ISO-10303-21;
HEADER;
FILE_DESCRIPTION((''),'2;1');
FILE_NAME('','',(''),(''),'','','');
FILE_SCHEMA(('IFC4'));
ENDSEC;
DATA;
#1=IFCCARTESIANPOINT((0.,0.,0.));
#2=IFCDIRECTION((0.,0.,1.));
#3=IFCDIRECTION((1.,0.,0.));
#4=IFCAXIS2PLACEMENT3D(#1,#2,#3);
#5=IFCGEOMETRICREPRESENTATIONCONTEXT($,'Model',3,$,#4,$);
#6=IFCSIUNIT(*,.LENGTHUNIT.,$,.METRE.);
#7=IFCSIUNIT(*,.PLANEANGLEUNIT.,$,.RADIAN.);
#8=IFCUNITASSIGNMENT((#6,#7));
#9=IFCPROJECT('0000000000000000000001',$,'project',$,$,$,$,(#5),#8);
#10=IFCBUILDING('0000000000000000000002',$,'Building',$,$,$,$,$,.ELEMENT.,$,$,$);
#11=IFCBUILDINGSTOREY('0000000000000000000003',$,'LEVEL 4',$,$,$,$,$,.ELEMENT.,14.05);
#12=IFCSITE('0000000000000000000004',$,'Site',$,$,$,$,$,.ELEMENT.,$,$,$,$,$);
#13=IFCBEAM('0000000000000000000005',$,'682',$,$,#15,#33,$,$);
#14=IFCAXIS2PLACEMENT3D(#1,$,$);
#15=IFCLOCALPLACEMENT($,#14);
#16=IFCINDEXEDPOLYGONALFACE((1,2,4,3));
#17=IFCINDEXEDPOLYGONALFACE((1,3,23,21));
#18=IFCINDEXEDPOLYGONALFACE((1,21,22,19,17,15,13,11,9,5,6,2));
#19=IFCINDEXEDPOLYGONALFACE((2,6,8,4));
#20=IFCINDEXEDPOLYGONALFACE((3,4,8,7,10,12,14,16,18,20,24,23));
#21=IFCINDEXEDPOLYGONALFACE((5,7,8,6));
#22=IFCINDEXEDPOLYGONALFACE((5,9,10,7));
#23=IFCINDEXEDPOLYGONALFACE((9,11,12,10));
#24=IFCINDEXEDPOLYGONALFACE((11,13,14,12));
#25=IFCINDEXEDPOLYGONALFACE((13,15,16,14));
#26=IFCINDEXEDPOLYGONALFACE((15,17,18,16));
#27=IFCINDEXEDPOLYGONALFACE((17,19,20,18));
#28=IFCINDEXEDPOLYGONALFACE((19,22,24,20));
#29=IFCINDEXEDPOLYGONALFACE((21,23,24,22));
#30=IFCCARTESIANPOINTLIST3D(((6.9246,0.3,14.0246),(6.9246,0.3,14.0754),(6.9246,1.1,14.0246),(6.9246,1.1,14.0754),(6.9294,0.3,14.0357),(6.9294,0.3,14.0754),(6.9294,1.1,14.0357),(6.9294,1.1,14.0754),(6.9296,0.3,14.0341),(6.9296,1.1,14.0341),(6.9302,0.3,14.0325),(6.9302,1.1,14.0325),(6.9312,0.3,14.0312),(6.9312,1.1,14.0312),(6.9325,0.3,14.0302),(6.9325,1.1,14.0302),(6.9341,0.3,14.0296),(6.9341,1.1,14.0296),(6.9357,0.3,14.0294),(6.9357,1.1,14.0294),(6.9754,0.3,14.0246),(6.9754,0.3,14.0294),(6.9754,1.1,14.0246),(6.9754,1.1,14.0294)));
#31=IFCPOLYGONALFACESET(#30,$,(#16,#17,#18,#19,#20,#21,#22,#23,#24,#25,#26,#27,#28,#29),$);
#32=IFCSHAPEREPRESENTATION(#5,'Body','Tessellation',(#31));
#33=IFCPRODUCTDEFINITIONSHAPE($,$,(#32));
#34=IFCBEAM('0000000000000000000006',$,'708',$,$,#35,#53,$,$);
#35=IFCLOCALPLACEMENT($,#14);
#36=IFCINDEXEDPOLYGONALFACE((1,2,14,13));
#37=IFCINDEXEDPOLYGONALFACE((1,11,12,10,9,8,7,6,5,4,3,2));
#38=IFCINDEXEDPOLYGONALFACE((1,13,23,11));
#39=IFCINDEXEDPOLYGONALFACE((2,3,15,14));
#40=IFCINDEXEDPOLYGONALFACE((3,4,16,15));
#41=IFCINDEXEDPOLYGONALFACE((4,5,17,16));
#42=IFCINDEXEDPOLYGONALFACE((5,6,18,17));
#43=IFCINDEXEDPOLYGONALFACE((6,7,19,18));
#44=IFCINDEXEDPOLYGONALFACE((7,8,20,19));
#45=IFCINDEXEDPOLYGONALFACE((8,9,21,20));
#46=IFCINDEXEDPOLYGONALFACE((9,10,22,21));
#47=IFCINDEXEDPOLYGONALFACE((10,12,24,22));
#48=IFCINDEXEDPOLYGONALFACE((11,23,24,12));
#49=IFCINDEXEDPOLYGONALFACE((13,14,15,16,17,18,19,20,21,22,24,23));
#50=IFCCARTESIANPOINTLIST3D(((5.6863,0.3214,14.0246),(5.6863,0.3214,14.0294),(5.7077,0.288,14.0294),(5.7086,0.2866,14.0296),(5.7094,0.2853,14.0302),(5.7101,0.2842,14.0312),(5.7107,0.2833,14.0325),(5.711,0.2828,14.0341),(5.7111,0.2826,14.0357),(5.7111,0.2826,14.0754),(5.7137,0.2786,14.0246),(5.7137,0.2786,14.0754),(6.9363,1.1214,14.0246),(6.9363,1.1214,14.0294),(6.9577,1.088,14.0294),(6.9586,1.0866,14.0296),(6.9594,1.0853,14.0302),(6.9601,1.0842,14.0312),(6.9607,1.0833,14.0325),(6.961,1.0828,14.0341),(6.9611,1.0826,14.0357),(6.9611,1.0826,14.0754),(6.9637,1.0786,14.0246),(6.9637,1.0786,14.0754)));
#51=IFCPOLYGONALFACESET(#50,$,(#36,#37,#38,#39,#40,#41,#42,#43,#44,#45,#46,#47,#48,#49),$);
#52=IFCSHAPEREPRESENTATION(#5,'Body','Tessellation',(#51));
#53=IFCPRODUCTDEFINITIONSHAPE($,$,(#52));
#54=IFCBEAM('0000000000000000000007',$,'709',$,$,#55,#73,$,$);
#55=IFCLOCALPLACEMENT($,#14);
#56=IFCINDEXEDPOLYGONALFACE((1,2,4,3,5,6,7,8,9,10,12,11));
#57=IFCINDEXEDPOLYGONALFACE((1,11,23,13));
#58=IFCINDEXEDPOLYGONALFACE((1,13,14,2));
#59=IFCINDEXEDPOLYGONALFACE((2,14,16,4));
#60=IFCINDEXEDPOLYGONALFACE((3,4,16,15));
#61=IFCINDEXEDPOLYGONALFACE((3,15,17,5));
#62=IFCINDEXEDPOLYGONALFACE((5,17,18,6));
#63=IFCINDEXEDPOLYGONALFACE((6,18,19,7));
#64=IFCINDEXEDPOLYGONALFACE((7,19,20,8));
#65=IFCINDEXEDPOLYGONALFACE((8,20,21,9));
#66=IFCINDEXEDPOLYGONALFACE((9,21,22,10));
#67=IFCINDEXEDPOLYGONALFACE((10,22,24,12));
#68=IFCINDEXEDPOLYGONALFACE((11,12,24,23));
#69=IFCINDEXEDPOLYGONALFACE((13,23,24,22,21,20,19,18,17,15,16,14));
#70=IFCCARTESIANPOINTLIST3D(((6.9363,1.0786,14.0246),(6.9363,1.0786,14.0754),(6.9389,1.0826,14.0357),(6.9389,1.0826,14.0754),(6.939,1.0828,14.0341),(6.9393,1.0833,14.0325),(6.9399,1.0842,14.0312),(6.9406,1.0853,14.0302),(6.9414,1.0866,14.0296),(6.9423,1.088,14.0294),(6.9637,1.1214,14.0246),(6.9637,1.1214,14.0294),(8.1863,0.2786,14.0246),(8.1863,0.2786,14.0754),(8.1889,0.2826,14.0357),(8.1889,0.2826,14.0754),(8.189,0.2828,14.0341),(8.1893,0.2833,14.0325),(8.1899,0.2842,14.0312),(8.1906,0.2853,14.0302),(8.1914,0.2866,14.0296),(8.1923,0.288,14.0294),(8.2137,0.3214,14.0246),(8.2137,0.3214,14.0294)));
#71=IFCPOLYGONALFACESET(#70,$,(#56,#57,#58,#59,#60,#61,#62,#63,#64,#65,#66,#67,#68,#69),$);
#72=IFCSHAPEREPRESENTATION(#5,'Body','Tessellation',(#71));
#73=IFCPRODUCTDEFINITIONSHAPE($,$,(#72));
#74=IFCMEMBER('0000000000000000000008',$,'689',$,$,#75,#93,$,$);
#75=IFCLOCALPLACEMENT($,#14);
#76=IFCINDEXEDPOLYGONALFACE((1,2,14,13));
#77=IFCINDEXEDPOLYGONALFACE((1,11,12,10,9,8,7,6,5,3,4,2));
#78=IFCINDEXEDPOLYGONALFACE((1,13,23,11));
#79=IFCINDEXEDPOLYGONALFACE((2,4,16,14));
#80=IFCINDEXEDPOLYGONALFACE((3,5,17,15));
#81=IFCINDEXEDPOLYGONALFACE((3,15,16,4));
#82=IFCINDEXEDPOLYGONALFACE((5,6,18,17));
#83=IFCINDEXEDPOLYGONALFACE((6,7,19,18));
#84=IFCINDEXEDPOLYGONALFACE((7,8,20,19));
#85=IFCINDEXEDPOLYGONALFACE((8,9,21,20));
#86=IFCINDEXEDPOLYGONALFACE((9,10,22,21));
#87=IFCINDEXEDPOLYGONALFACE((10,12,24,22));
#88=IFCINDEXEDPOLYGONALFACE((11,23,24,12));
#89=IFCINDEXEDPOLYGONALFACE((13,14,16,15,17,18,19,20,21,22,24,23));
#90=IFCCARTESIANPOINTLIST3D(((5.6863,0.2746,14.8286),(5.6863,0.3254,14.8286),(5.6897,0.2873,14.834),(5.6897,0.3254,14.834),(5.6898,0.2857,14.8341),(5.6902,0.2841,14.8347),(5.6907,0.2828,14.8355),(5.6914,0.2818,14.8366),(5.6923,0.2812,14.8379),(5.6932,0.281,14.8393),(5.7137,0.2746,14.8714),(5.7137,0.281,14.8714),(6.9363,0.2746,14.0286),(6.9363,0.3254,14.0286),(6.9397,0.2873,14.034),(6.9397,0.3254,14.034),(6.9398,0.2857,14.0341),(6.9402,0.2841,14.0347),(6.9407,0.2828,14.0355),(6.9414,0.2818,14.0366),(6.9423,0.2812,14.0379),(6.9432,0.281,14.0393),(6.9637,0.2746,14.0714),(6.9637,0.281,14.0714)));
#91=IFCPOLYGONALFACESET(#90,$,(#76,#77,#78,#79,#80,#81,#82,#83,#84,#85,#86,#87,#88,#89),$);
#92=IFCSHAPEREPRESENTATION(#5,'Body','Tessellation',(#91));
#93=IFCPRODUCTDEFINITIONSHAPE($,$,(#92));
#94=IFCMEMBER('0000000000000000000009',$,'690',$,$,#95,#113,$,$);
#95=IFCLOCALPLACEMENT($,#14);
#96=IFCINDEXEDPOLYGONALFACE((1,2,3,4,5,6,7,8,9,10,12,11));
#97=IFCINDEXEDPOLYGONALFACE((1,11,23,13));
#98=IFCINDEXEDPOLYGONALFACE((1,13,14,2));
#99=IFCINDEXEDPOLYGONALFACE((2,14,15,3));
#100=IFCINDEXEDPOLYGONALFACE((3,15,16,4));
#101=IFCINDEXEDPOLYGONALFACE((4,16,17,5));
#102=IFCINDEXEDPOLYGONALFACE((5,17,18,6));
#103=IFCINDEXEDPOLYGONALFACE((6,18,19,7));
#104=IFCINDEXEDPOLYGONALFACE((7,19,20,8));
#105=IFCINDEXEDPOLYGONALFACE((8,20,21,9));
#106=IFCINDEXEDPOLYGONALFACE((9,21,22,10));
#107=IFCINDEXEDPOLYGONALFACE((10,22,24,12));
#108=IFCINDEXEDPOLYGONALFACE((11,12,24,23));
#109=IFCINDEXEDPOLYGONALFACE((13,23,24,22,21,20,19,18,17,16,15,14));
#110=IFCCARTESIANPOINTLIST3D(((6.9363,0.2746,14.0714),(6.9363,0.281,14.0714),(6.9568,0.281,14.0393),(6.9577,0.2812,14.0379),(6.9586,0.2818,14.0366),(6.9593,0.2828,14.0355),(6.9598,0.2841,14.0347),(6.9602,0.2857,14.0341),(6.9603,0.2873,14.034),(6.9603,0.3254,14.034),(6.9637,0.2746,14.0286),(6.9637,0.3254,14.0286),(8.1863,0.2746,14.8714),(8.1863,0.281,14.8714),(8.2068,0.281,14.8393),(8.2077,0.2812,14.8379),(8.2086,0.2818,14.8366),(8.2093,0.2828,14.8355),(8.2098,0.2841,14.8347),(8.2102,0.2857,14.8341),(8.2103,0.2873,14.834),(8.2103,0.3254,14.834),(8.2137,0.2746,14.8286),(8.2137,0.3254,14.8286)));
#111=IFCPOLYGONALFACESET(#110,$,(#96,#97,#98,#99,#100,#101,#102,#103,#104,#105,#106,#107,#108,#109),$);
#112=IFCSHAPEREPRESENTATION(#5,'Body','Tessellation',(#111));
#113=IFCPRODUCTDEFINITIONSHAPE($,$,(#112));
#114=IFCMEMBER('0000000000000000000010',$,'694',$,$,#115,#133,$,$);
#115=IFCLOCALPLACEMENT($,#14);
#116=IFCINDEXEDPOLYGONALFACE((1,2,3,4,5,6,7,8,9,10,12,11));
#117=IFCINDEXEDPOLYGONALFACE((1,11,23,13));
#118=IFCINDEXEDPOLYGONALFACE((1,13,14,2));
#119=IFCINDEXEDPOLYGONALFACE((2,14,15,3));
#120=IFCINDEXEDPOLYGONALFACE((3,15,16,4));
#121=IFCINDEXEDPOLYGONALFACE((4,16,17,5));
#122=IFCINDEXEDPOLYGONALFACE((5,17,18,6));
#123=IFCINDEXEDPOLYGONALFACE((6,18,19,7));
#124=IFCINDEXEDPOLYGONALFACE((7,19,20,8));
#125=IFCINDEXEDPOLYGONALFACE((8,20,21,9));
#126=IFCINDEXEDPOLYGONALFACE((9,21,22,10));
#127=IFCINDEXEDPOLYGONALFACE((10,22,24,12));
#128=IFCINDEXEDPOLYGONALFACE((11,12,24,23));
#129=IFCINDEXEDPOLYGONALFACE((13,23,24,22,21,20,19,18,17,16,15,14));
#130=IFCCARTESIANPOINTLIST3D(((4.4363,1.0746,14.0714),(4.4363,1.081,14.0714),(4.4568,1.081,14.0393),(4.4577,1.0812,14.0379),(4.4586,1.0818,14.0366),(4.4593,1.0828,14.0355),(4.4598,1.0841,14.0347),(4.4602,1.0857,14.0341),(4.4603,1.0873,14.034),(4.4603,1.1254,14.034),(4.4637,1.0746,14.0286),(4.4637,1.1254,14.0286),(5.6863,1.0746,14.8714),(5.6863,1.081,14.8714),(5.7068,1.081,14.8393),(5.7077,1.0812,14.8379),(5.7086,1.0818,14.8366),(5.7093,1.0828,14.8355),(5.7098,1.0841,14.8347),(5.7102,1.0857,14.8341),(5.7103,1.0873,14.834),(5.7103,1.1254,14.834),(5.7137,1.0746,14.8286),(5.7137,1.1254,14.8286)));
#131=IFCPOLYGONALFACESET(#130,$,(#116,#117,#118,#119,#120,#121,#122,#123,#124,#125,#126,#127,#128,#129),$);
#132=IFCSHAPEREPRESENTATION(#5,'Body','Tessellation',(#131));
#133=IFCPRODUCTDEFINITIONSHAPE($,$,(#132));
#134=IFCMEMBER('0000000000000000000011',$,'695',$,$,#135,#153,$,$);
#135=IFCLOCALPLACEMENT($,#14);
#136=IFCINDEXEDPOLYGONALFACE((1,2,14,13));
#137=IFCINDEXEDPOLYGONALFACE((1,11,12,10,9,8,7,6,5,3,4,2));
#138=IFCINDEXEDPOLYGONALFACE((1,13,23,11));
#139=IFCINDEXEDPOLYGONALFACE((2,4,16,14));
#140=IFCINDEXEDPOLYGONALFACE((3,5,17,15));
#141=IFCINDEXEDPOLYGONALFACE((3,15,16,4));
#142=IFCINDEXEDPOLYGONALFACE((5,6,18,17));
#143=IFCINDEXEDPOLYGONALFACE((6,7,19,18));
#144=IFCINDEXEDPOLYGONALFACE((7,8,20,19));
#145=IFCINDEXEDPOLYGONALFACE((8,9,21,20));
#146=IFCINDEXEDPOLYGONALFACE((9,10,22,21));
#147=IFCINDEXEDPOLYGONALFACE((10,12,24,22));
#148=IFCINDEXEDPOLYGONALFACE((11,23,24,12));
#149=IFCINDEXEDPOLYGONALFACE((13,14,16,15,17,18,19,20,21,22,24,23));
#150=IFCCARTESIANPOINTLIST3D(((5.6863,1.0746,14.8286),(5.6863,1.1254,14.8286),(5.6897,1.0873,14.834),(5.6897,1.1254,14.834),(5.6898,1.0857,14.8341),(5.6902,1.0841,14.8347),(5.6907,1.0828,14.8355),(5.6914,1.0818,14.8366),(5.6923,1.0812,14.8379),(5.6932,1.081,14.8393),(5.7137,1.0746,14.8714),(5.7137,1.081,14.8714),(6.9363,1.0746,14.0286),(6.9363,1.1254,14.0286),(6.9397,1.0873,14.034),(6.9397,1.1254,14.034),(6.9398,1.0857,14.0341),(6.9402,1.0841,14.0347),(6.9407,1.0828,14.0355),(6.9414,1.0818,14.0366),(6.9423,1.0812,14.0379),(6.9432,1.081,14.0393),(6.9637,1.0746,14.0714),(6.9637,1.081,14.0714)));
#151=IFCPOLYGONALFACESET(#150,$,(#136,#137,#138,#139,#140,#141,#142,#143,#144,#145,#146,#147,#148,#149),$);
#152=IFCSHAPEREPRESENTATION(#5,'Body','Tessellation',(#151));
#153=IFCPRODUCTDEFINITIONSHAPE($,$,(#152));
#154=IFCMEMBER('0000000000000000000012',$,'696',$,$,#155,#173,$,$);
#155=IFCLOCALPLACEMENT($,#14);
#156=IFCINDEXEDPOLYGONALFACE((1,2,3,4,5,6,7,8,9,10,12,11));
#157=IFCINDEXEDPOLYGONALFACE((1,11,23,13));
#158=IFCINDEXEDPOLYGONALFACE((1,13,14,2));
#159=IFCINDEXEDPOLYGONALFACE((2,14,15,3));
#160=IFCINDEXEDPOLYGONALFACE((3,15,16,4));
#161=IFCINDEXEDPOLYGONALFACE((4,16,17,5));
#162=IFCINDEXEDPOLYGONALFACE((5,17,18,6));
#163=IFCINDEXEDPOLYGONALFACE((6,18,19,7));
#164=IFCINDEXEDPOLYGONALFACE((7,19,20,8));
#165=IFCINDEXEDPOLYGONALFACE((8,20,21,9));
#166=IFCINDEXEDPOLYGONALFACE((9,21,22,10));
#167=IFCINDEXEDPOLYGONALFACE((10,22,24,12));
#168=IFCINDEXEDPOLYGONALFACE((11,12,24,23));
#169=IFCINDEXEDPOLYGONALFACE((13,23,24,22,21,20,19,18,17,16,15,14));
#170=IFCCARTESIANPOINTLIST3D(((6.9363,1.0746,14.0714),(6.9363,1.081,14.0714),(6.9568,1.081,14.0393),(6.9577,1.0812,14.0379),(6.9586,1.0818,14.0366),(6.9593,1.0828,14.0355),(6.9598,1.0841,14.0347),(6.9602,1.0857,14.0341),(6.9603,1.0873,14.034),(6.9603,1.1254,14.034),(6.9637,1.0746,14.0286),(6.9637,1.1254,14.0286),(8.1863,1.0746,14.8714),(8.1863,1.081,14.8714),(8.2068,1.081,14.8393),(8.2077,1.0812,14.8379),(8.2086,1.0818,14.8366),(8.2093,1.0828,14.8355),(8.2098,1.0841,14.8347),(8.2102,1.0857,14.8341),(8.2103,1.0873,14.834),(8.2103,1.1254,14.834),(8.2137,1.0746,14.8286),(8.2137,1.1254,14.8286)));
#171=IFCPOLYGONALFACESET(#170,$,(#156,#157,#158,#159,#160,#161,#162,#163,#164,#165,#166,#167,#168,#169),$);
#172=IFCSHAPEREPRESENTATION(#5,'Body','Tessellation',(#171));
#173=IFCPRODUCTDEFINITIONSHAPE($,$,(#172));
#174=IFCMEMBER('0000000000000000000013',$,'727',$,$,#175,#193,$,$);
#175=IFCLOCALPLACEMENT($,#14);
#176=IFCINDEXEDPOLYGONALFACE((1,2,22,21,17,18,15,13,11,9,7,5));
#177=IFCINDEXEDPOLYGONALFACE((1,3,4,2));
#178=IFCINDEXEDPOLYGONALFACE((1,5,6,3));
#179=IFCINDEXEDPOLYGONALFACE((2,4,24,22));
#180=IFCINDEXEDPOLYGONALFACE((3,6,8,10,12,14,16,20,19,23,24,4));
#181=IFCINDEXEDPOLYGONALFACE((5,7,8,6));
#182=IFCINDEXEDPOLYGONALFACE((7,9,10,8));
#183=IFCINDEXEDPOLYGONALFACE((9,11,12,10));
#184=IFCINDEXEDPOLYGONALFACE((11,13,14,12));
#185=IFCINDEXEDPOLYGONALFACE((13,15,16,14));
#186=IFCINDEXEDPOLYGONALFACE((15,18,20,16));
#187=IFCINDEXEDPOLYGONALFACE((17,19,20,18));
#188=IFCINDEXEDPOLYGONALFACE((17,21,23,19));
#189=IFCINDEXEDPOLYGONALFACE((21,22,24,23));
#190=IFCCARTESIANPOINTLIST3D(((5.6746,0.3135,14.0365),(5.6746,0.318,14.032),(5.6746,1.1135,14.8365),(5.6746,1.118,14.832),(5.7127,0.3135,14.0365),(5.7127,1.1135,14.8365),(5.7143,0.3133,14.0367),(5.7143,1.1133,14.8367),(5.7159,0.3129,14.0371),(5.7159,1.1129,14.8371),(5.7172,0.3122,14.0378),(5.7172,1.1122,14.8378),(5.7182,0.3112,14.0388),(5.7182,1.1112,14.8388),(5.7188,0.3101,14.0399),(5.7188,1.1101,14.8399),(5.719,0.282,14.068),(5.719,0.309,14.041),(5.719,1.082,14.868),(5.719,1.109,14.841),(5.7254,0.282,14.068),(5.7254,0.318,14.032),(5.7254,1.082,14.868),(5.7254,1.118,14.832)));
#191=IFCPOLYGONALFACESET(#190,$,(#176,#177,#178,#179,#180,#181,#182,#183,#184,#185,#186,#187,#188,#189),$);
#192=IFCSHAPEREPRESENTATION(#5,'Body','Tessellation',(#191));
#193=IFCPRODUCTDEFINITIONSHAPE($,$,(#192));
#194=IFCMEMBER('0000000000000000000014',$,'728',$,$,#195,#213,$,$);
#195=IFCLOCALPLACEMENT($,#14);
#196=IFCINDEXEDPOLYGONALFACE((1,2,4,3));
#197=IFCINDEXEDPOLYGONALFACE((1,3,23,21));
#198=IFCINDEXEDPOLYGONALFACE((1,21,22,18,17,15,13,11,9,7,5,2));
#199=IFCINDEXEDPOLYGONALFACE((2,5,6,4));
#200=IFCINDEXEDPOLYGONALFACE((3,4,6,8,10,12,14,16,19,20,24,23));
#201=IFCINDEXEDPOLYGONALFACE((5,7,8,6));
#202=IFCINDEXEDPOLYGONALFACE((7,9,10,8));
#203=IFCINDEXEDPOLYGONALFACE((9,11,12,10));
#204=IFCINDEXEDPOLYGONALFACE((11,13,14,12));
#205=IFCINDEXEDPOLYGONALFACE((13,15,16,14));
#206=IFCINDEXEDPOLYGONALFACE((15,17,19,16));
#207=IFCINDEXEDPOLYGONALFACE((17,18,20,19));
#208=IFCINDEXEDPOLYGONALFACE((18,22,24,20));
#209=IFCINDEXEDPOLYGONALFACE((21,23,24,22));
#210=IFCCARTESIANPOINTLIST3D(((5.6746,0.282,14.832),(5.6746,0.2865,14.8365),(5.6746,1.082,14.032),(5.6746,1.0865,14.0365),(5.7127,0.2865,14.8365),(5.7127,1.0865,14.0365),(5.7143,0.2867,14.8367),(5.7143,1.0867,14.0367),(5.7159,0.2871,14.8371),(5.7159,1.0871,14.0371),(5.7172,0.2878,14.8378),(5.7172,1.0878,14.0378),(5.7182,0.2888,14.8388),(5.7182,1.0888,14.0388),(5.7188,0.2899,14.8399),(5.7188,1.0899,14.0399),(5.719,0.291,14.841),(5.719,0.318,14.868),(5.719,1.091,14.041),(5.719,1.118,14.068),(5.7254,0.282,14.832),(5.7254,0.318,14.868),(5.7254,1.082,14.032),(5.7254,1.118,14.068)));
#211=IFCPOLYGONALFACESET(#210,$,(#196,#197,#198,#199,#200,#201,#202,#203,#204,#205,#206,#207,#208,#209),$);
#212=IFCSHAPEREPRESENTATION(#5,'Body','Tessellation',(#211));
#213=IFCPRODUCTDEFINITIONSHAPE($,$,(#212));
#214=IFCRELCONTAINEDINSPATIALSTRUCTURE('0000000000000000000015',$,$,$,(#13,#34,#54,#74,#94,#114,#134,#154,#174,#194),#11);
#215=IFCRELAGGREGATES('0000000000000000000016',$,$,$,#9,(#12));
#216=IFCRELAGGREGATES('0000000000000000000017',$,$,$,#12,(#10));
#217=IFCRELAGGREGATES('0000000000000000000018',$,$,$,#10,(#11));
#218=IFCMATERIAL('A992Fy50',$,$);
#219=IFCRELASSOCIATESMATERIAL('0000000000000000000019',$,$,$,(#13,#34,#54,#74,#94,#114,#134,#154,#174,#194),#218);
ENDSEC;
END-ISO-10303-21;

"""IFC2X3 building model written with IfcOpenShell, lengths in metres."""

from ifc_helpers import new_model, si_unit, frame, origin_with_axes, origin_2d_with_axis, place, context, project, spatial, l_section, extrude, material, element, save


model = new_model("IFC2X3")

# Units and contexts
model_context = context("Model", 3, world=origin_with_axes())
ifc_project = project(units=[si_unit("LENGTHUNIT", "METRE"), si_unit("PLANEANGLEUNIT", "RADIAN")], contexts=[model_context])

# Site, building, storey
site = spatial("IfcSite", under=ifc_project, Name="Site", CompositionType="ELEMENT")
building = spatial("IfcBuilding", under=site, Name="Building", CompositionType="ELEMENT")
storey = spatial("IfcBuildingStorey", under=building, Name="LEVEL 4", CompositionType="ELEMENT", Elevation=14.05)

# Shared definitions
ifc_material = material(Name="A992Fy50")

# Beams
for number, where, z_axis, x_axis, name in (
    (1, (6.95, 1.1, 14.05), (0.0, -1.0, 0.0), (1.0, 0.0, 0.0), "682"),
):
    element("IfcBeam", number, at=place(None, frame(where, z_axis=z_axis, x_axis=x_axis)), inside=storey, material=ifc_material, Name=name, context=model_context, shape_type="SweptSolid", body=[
        extrude(l_section(Depth=0.0508, Width=0.0508, Thickness=0.0048, FilletRadius=0.0063, at=origin_2d_with_axis()), origin_with_axes(), (0.0, 0.0, 1.0), 0.8),
    ])
for number, where, z_axis, x_axis, name in (
    (2, (5.7, 0.3, 14.05), (0.842271, 0.539054, 0.0), (-0.539054, 0.842271, 0.0), "708"),
    (3, (6.95, 1.1, 14.05), (0.842271, -0.539054, 0.0), (0.539054, 0.842271, 0.0), "709"),
):
    element("IfcBeam", number, at=place(None, frame(where, z_axis=z_axis, x_axis=x_axis)), inside=storey, material=ifc_material, Name=name, context=model_context, shape_type="SweptSolid", body=[
        extrude(l_section(Depth=0.0508, Width=0.0508, Thickness=0.0048, FilletRadius=0.0063, at=origin_2d_with_axis()), origin_with_axes(), (0.0, 0.0, 1.0), 1.4841),
    ])

# Members
for number, where, z_axis, x_axis, name in (
    (4, (5.7, 0.3, 14.85), (0.842271, 0.0, -0.539054), (0.0, 1.0, 0.0), "689"),
    (5, (6.95, 0.3, 14.05), (0.842271, 0.0, 0.539054), (0.0, 1.0, 0.0), "690"),
    (6, (4.45, 1.1, 14.05), (0.842271, 0.0, 0.539054), (0.0, 1.0, 0.0), "694"),
    (7, (5.7, 1.1, 14.85), (0.842271, 0.0, -0.539054), (0.0, 1.0, 0.0), "695"),
    (8, (6.95, 1.1, 14.05), (0.842271, 0.0, 0.539054), (0.0, 1.0, 0.0), "696"),
):
    element("IfcMember", number, at=place(None, frame(where, z_axis=z_axis, x_axis=x_axis)), inside=storey, material=ifc_material, Name=name, context=model_context, shape_type="SweptSolid", body=[
        extrude(l_section(Depth=0.0508, Width=0.0508, Thickness=0.0063, FilletRadius=0.0063, at=origin_2d_with_axis()), origin_with_axes(), (0.0, 0.0, 1.0), 1.4841),
    ])
for number, where, z_axis, x_axis, name in (
    (9, (5.7, 0.3, 14.05), (0.0, 0.707107, 0.707107), (-1.0, 0.0, 0.0), "727"),
    (10, (5.7, 0.3, 14.85), (0.0, 0.707107, -0.707107), (-1.0, 0.0, 0.0), "728"),
):
    element("IfcMember", number, at=place(None, frame(where, z_axis=z_axis, x_axis=x_axis)), inside=storey, material=ifc_material, Name=name, context=model_context, shape_type="SweptSolid", body=[
        extrude(l_section(Depth=0.0508, Width=0.0508, Thickness=0.0063, FilletRadius=0.0063, at=origin_2d_with_axis()), origin_with_axes(), (0.0, 0.0, 1.0), 1.1314),
    ])

save(model, "model.ifc")
